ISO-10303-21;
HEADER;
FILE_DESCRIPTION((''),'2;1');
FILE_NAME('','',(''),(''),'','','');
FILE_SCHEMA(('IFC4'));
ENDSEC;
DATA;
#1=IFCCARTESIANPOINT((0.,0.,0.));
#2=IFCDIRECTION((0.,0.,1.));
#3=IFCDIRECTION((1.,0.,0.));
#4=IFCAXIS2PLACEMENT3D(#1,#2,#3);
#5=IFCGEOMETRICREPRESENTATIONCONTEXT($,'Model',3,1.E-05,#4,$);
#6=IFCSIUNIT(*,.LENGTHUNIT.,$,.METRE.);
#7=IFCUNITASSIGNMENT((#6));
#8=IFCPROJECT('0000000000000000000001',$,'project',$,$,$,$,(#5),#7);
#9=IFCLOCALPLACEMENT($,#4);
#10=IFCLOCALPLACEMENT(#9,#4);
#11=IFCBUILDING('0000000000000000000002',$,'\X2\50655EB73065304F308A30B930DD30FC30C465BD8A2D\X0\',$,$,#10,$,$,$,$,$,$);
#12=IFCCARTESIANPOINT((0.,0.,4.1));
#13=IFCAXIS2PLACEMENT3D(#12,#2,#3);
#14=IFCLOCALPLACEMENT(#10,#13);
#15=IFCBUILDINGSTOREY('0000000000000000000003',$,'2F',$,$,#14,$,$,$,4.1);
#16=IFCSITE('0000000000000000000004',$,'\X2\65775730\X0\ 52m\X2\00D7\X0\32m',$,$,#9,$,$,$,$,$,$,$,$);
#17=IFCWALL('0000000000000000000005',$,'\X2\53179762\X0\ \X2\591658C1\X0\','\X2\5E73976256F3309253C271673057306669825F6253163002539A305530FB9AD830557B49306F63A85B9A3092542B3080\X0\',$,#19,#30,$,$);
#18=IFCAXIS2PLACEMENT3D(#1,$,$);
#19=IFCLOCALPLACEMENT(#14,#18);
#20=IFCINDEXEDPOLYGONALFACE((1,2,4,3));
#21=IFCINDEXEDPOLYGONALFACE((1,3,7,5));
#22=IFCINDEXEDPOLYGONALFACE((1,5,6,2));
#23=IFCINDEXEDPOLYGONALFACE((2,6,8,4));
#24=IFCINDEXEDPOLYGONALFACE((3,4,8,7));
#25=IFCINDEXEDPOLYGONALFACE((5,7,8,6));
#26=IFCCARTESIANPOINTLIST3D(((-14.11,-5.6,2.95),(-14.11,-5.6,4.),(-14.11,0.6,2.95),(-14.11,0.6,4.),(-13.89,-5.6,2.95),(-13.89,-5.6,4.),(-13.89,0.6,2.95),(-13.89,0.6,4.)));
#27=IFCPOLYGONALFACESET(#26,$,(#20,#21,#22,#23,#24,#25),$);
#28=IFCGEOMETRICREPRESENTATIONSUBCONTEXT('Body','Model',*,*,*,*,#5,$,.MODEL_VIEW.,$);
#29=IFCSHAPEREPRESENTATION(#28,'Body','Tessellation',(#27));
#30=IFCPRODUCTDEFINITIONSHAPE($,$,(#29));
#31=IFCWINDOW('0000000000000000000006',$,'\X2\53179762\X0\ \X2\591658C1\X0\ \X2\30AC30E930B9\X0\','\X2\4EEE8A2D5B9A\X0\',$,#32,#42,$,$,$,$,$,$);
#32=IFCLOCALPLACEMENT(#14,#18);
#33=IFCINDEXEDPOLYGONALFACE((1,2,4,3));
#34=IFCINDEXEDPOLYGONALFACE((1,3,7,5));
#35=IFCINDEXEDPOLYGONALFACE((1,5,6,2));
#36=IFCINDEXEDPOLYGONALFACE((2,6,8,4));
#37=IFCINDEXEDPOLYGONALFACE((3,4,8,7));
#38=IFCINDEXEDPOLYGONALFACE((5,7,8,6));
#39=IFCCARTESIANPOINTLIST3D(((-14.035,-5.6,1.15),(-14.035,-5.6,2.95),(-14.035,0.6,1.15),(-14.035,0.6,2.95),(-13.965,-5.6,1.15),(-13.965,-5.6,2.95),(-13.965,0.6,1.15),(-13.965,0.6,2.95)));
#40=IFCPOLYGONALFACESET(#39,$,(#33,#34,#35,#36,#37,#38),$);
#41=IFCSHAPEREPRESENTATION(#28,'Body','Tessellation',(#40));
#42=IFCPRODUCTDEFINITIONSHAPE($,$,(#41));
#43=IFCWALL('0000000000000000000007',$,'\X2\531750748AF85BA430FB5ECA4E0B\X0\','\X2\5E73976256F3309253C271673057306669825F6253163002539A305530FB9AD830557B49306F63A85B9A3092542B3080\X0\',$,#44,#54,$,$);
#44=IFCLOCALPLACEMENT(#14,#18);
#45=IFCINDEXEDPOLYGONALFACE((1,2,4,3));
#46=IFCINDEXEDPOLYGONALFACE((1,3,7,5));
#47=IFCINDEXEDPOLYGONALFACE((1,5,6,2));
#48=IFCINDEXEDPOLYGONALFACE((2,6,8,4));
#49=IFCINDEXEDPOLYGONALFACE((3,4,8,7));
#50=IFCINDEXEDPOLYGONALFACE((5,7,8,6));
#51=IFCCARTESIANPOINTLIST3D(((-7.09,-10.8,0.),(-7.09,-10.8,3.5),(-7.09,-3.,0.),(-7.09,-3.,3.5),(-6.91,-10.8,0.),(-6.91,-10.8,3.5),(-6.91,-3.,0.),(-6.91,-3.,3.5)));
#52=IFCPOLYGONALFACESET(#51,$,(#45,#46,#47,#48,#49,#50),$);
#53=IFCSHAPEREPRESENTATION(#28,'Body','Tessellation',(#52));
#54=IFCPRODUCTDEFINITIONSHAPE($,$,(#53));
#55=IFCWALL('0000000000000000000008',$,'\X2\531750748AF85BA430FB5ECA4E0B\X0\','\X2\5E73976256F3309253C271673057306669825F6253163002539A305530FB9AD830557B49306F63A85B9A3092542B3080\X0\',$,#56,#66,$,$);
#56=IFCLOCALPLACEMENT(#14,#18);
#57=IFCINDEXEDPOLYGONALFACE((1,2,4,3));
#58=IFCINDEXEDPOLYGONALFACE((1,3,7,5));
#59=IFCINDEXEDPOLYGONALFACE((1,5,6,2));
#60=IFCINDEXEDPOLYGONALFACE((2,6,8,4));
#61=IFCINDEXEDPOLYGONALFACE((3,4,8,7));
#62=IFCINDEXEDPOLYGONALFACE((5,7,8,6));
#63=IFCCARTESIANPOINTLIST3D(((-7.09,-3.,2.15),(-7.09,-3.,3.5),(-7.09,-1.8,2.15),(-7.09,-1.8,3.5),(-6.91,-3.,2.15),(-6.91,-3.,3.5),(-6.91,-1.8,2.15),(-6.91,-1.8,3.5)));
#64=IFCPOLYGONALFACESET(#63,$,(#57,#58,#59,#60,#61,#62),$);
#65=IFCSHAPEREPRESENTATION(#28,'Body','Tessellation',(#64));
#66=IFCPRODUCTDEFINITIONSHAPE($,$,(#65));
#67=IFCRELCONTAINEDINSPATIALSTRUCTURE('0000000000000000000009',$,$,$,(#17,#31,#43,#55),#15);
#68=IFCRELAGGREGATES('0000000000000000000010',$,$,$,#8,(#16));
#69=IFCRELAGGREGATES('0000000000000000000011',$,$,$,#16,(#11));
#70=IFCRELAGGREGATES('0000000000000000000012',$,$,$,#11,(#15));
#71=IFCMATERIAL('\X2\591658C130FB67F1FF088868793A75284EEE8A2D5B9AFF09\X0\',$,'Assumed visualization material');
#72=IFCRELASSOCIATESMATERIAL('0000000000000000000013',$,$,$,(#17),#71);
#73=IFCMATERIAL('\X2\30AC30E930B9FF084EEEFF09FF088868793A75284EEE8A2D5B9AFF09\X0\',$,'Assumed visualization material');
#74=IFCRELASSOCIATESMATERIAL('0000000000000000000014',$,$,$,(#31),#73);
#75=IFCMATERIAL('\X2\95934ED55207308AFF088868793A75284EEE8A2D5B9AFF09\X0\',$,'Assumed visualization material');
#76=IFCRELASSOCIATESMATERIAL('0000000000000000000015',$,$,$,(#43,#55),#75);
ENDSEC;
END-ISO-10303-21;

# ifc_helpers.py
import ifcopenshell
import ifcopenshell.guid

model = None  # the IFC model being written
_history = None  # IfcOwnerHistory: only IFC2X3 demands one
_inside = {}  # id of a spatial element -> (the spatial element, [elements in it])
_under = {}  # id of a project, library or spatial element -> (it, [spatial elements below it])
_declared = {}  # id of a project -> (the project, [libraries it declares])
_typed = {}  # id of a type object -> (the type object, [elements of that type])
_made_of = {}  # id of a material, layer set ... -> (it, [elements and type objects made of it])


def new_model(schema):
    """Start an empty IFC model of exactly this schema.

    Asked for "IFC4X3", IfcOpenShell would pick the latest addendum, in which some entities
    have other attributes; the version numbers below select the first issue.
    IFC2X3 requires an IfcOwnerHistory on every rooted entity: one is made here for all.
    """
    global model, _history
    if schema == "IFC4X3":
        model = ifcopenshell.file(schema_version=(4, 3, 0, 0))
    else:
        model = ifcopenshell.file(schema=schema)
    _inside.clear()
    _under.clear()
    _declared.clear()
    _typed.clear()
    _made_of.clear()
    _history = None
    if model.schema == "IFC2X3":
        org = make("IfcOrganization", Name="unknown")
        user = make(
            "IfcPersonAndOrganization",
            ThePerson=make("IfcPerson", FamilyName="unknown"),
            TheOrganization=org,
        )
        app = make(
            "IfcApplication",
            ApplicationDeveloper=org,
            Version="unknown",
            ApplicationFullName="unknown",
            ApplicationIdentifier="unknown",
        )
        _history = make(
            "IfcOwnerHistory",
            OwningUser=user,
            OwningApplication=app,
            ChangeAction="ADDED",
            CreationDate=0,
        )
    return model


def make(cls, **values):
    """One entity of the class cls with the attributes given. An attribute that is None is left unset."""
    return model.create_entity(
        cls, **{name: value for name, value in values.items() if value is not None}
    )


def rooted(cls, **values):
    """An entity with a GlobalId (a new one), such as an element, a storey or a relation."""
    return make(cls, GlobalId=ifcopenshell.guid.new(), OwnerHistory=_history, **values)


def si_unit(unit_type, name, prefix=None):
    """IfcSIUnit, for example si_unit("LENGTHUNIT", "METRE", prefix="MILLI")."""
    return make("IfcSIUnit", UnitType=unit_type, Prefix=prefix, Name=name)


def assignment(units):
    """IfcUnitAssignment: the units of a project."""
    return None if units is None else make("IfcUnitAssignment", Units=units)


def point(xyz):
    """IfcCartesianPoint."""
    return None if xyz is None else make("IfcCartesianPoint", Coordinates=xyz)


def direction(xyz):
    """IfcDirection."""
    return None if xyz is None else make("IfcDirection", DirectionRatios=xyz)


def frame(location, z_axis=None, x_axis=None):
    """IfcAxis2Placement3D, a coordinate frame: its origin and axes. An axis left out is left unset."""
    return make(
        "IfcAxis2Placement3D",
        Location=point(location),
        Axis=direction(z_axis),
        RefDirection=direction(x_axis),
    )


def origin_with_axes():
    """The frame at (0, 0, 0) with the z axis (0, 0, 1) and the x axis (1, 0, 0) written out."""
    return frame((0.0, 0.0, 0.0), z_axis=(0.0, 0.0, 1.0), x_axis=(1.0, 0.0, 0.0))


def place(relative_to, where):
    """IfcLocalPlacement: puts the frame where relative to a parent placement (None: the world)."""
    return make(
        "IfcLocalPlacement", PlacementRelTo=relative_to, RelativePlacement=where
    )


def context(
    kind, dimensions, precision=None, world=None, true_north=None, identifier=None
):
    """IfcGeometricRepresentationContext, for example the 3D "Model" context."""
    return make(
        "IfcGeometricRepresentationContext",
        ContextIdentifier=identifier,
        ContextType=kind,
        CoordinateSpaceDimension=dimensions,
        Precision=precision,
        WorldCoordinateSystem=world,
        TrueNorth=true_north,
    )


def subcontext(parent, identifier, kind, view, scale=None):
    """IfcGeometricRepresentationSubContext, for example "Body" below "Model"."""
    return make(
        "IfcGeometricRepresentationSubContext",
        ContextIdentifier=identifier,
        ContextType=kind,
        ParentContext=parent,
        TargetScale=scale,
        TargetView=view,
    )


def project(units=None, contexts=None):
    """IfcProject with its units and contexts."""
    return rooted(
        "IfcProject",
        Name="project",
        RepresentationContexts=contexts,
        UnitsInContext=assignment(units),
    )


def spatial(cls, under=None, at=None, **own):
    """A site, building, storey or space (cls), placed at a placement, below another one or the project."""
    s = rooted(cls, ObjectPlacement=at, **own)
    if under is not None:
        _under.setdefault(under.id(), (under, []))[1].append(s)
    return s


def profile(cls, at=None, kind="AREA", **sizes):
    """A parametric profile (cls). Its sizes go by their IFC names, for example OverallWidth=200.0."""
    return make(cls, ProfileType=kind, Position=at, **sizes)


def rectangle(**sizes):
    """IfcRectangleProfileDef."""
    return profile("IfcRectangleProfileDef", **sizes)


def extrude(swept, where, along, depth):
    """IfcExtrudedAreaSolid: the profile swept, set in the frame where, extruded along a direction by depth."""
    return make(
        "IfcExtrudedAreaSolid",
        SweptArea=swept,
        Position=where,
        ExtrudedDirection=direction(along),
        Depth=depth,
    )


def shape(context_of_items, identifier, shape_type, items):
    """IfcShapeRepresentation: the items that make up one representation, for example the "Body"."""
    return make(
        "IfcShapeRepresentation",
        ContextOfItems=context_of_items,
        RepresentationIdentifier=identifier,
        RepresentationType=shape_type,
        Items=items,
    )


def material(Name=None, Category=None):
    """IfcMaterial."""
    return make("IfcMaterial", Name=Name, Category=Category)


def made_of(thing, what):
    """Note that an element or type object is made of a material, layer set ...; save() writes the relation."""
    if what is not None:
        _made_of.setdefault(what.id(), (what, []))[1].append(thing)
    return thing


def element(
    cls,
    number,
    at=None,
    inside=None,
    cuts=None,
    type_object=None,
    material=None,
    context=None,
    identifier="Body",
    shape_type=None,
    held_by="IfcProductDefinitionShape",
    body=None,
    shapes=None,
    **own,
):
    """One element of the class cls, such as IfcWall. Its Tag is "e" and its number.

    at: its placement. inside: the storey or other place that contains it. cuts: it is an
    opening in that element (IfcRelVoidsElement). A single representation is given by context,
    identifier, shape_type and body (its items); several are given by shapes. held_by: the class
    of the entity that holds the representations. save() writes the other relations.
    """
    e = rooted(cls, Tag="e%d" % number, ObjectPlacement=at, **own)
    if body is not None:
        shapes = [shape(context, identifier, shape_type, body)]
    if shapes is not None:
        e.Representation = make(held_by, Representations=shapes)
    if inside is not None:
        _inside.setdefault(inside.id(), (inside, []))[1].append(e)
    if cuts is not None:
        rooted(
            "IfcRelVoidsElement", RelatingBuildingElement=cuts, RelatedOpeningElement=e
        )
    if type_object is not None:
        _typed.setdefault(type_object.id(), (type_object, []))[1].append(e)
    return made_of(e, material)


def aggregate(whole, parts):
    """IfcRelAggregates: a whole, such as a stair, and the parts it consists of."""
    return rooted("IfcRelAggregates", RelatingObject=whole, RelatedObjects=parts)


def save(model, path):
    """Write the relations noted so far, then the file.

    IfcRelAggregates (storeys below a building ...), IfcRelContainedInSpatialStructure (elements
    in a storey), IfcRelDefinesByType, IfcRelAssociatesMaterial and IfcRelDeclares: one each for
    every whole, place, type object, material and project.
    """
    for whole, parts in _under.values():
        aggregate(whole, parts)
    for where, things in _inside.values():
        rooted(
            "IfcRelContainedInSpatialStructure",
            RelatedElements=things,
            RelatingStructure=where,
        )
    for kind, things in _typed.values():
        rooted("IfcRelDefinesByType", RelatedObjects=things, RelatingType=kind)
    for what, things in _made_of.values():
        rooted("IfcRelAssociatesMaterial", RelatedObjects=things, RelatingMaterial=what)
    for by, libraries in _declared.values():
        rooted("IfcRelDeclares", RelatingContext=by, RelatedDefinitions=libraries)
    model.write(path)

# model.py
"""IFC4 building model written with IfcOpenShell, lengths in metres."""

from ifc_helpers import new_model, si_unit, frame, origin_with_axes, place, context, subcontext, project, spatial, rectangle, extrude, material, element, save


model = new_model("IFC4")

# Units and contexts
model_context = context("Model", 3, precision=1e-05, world=origin_with_axes())
body_context = subcontext(model_context, "Body", "Model", "MODEL_VIEW")
ifc_project = project(units=[si_unit("LENGTHUNIT", "METRE")], contexts=[model_context])

# Site, building, storey
site_placement = place(None, origin_with_axes())
site = spatial("IfcSite", under=ifc_project, at=site_placement, Name="敷地 52m×32m")
building_placement = place(site_placement, origin_with_axes())
building = spatial("IfcBuilding", under=site, at=building_placement, Name="健康づくりスポーツ施設")
storey_placement = place(building_placement, frame((0.0, 0.0, 4.1), z_axis=(0.0, 0.0, 1.0), x_axis=(1.0, 0.0, 0.0)))
storey = spatial("IfcBuildingStorey", under=building, at=storey_placement, Name="2F", Elevation=4.1)

# Wall
ifc_material_1 = material(Name="外壁・柱（表示用仮設定）", Category="Assumed visualization material")
wall_1_placement = place(storey_placement, frame((-14.0, -2.5, 2.95), z_axis=(0.0, 0.0, 1.0), x_axis=(1.0, 0.0, 0.0)))
element("IfcWall", 1, at=wall_1_placement, inside=storey, material=ifc_material_1, Name="北面 外壁", Description="平面図を参照して概形化。厚さ・高さ等は推定を含む", context=body_context, shape_type="SweptSolid", body=[
    extrude(rectangle(XDim=0.22, YDim=6.2), origin_with_axes(), (0.0, 0.0, 1.0), 1.05),
])

# Window
ifc_material_2 = material(Name="ガラス（仮）（表示用仮設定）", Category="Assumed visualization material")
window_placement = place(storey_placement, frame((-14.0, -2.5, 1.15), z_axis=(0.0, 0.0, 1.0), x_axis=(1.0, 0.0, 0.0)))
element("IfcWindow", 2, at=window_placement, inside=storey, material=ifc_material_2, Name="北面 外壁 ガラス", Description="仮設定", context=body_context, shape_type="SweptSolid", body=[
    extrude(rectangle(XDim=0.07, YDim=6.2), origin_with_axes(), (0.0, 0.0, 1.0), 1.8),
])

# Walls
ifc_material_3 = material(Name="間仕切り（表示用仮設定）", Category="Assumed visualization material")
wall_2_placement = place(storey_placement, frame((-7.0, -6.9, 0.0), z_axis=(0.0, 0.0, 1.0), x_axis=(1.0, 0.0, 0.0)))
element("IfcWall", 3, at=wall_2_placement, inside=storey, material=ifc_material_3, Name="北側諸室・廊下", Description="平面図を参照して概形化。厚さ・高さ等は推定を含む", context=body_context, shape_type="SweptSolid", body=[
    extrude(rectangle(XDim=0.18, YDim=7.8), origin_with_axes(), (0.0, 0.0, 1.0), 3.5),
])
wall_3_placement = place(storey_placement, frame((-7.0, -2.4, 2.15), z_axis=(0.0, 0.0, 1.0), x_axis=(1.0, 0.0, 0.0)))
element("IfcWall", 4, at=wall_3_placement, inside=storey, material=ifc_material_3, Name="北側諸室・廊下", Description="平面図を参照して概形化。厚さ・高さ等は推定を含む", context=body_context, shape_type="SweptSolid", body=[
    extrude(rectangle(XDim=0.18, YDim=1.2), origin_with_axes(), (0.0, 0.0, 1.0), 1.35),
])

save(model, "model.ifc")
